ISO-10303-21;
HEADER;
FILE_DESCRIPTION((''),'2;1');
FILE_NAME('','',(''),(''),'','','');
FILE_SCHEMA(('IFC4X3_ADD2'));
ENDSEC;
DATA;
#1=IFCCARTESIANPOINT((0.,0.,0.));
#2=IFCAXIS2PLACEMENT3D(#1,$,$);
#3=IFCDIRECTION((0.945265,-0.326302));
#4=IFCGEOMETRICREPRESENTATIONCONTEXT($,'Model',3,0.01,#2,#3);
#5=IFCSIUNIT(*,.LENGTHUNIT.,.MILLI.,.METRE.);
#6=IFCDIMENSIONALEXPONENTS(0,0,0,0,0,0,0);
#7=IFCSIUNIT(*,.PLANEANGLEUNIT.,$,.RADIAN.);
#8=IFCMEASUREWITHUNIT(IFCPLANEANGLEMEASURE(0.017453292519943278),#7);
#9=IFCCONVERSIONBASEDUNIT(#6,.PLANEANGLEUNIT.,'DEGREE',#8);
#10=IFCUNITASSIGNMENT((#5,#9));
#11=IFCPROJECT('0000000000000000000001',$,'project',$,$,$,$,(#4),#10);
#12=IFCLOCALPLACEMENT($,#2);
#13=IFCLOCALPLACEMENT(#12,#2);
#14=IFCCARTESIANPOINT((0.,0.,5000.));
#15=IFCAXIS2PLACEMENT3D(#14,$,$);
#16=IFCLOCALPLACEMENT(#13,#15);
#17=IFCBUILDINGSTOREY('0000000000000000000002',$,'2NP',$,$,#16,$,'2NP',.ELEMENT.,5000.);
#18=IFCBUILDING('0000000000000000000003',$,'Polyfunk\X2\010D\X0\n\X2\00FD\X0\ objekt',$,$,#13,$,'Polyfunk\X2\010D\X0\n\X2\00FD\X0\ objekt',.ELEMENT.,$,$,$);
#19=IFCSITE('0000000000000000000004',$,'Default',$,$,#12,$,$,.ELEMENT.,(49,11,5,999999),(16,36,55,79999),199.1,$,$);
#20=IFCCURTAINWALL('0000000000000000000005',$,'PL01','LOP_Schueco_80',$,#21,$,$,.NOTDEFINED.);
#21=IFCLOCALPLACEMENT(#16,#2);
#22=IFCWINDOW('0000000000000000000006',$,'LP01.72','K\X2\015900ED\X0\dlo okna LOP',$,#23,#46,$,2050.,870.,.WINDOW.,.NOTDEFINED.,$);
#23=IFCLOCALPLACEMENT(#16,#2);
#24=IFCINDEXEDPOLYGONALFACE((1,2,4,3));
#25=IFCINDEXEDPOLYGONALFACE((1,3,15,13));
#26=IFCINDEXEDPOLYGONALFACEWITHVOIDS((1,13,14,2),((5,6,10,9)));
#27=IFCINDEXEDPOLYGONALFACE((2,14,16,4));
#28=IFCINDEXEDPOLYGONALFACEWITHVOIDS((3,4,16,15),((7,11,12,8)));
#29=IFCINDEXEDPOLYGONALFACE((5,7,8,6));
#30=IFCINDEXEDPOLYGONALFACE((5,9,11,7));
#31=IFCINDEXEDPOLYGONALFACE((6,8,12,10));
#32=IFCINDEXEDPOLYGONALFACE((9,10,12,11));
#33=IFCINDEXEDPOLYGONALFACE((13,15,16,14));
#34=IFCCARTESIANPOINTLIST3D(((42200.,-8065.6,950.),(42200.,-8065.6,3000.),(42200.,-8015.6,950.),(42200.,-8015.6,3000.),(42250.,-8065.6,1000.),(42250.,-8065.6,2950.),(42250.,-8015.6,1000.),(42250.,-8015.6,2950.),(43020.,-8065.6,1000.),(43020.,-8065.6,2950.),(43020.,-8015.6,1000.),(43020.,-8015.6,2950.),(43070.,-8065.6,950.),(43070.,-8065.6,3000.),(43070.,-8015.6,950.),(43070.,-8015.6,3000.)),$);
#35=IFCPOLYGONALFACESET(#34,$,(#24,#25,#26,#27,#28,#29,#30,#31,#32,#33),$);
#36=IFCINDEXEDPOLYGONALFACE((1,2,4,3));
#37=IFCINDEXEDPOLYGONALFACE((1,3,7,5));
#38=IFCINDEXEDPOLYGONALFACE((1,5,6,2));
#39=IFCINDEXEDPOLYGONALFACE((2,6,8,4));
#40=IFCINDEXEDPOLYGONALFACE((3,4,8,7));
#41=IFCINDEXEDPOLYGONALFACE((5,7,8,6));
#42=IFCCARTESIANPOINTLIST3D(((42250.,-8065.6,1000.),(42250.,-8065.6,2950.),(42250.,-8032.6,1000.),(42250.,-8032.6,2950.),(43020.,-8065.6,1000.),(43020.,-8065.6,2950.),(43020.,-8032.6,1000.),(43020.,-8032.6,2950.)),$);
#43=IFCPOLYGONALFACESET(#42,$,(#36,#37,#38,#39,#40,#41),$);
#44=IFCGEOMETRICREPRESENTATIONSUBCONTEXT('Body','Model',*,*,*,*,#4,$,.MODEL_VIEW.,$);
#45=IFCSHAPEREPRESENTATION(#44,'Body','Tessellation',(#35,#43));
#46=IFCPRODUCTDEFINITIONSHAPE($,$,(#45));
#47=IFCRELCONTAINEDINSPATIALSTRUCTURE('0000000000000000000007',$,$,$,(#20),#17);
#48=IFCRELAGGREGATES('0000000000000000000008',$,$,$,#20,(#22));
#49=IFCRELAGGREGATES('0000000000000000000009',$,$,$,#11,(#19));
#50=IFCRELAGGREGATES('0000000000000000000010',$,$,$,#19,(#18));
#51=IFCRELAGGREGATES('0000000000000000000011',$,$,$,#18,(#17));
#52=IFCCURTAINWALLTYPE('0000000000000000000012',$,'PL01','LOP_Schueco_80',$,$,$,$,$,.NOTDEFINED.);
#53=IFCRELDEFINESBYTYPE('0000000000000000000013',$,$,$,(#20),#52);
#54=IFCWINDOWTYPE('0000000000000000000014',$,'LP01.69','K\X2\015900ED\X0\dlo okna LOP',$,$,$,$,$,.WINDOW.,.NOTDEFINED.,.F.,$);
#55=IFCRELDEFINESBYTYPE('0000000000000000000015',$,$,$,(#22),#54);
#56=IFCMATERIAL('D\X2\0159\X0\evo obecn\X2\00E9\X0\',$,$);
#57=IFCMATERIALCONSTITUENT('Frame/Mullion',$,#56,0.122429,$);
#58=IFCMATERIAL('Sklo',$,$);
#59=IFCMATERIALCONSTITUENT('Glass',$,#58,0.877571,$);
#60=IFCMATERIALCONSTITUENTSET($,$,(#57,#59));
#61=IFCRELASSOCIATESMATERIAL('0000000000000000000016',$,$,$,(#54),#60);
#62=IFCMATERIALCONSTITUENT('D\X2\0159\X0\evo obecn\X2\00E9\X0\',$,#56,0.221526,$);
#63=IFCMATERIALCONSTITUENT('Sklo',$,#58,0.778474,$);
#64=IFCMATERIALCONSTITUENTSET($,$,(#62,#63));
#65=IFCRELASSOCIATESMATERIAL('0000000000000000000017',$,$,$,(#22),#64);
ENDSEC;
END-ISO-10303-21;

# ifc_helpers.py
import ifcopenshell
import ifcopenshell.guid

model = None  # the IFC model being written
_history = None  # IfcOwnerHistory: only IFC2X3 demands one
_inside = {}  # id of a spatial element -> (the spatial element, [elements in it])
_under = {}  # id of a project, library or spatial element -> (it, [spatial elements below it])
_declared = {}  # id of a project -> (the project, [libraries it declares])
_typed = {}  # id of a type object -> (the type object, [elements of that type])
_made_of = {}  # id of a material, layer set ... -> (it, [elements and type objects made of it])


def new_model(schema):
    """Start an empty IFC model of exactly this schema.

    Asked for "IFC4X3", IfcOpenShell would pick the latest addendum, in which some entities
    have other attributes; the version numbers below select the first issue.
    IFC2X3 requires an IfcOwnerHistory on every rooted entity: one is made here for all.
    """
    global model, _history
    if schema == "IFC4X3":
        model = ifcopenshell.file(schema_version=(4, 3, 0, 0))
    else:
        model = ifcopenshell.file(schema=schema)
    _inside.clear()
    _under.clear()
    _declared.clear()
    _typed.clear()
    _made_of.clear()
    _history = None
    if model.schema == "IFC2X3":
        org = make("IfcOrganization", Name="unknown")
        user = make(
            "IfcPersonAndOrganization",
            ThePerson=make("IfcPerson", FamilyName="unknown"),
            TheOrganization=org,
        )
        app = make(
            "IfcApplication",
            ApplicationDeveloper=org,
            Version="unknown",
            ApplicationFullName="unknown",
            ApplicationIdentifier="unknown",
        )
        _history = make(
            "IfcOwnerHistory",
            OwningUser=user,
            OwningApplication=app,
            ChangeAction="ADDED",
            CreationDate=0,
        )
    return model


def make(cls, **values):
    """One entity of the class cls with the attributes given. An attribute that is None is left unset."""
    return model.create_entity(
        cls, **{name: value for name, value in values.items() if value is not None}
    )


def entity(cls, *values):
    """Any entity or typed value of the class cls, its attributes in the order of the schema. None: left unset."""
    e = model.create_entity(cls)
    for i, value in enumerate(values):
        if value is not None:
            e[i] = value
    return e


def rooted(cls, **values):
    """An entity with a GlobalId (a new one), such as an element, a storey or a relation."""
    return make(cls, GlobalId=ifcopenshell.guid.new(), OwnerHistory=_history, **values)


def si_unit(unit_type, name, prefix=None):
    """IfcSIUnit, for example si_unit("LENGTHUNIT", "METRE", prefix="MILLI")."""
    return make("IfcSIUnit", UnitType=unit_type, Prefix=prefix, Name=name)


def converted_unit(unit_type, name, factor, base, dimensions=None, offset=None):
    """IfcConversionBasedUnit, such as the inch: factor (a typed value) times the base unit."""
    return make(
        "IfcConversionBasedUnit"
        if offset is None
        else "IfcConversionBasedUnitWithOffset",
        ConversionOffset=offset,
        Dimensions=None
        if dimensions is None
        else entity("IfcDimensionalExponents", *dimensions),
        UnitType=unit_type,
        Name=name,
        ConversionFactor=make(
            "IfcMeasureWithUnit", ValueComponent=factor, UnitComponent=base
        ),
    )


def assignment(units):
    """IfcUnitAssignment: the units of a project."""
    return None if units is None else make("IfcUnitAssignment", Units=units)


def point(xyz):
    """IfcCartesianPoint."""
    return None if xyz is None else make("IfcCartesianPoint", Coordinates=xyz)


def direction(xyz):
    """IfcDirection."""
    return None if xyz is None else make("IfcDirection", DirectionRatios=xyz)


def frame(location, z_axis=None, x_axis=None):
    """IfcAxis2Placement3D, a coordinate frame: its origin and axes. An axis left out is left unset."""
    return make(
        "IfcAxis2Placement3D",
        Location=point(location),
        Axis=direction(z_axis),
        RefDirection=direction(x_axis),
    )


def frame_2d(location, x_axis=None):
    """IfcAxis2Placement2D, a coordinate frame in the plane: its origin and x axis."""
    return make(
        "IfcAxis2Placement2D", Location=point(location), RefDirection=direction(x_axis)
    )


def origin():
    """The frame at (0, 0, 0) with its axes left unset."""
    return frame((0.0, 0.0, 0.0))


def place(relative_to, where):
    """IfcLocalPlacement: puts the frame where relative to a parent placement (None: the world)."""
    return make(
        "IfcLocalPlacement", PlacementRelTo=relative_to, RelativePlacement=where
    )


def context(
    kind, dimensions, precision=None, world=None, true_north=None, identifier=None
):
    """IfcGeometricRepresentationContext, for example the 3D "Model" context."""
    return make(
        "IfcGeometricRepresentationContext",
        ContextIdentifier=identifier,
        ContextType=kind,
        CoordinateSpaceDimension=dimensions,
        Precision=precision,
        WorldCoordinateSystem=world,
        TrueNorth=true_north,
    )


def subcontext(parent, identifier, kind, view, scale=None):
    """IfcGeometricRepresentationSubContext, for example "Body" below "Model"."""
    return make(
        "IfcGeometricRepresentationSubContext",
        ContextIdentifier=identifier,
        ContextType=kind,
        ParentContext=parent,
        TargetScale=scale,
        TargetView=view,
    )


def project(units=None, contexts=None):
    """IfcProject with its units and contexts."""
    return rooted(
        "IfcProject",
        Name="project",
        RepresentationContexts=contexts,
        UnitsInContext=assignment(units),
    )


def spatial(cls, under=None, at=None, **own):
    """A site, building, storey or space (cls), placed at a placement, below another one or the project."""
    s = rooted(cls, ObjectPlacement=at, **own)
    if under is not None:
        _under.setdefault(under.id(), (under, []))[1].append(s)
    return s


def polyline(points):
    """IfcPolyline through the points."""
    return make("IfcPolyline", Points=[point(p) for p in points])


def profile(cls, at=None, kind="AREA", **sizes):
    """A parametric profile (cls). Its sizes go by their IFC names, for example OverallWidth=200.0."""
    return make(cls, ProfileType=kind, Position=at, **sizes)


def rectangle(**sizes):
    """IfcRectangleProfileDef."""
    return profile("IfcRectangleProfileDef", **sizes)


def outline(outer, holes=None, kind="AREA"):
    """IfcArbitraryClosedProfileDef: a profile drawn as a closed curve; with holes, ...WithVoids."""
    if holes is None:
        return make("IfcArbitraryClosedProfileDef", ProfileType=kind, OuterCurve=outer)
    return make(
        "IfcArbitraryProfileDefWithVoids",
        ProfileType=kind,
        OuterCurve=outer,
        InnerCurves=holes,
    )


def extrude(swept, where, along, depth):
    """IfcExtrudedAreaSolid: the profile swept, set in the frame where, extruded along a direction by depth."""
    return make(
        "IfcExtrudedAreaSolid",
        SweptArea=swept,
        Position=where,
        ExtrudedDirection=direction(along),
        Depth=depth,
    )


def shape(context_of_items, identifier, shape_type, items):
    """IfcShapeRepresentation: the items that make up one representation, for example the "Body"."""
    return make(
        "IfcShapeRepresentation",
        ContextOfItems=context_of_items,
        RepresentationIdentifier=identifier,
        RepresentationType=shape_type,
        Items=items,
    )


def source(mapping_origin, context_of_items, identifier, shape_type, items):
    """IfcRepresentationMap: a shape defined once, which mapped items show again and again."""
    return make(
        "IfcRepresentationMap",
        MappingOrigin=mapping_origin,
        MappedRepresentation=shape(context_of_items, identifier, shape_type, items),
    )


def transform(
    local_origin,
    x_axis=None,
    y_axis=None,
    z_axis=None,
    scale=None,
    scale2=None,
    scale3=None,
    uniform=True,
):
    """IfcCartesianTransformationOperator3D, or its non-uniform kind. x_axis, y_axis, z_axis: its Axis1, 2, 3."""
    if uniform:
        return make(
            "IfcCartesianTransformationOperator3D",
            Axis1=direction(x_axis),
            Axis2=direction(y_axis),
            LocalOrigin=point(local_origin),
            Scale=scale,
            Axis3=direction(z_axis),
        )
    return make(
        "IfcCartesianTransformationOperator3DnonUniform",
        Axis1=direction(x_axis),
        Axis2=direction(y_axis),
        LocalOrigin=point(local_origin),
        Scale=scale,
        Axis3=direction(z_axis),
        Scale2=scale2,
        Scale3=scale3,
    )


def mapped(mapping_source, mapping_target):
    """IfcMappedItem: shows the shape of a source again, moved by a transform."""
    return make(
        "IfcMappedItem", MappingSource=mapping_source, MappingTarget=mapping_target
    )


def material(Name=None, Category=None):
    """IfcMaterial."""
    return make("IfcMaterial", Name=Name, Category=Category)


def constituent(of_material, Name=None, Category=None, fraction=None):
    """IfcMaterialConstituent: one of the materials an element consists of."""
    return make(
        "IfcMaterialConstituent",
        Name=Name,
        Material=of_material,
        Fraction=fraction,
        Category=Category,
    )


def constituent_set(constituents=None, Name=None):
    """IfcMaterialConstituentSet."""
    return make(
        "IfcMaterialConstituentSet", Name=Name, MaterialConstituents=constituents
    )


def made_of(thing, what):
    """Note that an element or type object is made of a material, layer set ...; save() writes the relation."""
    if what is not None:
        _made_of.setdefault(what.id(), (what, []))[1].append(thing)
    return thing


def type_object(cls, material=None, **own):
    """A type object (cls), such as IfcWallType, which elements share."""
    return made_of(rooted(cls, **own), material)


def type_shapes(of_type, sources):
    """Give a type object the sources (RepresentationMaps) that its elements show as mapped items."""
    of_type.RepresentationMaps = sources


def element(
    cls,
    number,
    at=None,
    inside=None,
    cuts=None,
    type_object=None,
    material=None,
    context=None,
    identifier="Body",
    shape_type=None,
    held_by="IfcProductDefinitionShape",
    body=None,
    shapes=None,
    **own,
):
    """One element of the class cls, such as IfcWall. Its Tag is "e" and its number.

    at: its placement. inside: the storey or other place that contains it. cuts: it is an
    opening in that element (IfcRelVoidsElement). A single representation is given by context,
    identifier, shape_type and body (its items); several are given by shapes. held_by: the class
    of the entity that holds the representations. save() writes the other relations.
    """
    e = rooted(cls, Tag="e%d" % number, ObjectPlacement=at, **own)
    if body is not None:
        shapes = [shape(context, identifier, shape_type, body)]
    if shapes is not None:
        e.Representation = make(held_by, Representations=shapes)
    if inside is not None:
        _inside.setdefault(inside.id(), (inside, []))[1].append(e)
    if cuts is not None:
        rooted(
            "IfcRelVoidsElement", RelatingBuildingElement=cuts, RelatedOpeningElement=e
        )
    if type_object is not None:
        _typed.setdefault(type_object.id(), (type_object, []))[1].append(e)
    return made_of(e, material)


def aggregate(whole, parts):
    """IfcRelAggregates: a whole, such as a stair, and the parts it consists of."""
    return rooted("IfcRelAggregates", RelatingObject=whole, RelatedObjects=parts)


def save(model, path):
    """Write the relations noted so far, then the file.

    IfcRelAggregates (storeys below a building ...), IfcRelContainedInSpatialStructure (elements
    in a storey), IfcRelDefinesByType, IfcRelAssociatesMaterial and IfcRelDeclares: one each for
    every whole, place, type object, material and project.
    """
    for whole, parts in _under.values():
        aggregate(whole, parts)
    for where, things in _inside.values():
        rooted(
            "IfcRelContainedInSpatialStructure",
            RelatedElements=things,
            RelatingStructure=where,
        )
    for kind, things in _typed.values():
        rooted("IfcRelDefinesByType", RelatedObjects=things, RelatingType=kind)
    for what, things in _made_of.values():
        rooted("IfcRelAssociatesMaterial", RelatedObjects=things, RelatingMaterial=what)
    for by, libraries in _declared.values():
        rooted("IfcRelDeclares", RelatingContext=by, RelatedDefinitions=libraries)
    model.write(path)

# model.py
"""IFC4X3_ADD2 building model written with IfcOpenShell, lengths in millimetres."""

from ifc_helpers import new_model, entity, si_unit, converted_unit, direction, frame, frame_2d, origin, place, context, subcontext, project, spatial, polyline, rectangle, outline, extrude, source, transform, mapped, material, constituent, constituent_set, type_object, type_shapes, element, aggregate, save


model = new_model("IFC4X3_ADD2")

# Units and contexts
model_context = context("Model", 3, precision=0.01, world=origin(), true_north=direction((0.945265, -0.326302)))
body_context = subcontext(model_context, "Body", "Model", "MODEL_VIEW")
ifc_project = project(units=[si_unit("LENGTHUNIT", "METRE", prefix="MILLI"), converted_unit("PLANEANGLEUNIT", "DEGREE", entity("IfcPlaneAngleMeasure", 0.017453292519943278), si_unit("PLANEANGLEUNIT", "RADIAN"), dimensions=[0, 0, 0, 0, 0, 0, 0])], contexts=[model_context])

# Site, building, storey
site_placement = place(None, origin())
site = spatial("IfcSite", under=ifc_project, at=site_placement, Name="Default", CompositionType="ELEMENT", RefLatitude=(49, 11, 5, 999999), RefLongitude=(16, 36, 55, 79999), RefElevation=199.1)
building_placement = place(site_placement, origin())
building = spatial("IfcBuilding", under=site, at=building_placement, Name="Polyfunkčný objekt", LongName="Polyfunkčný objekt", CompositionType="ELEMENT")
storey_placement = place(building_placement, frame((0.0, 0.0, 5000.0)))
storey = spatial("IfcBuildingStorey", under=building, at=storey_placement, Name="2NP", LongName="2NP", CompositionType="ELEMENT", Elevation=5000.0)

# Curtain wall
curtain_wall_type = type_object("IfcCurtainWallType", Name="PL01", Description="LOP_Schueco_80", PredefinedType="NOTDEFINED")
curtain_wall_placement = place(storey_placement, frame((0.0, 0.0, -5000.0)))
curtain_wall = element("IfcCurtainWall", 1, at=curtain_wall_placement, inside=storey, type_object=curtain_wall_type, Name="PL01", Description="LOP_Schueco_80", PredefinedType="NOTDEFINED")
ifc_material_1 = material(Name="Sklo")

# Window
ifc_material_2 = material(Name="Dřevo obecné")
ifc_constituent_1 = constituent(ifc_material_2, Name="Dřevo obecné", fraction=0.221526)
ifc_constituent_2 = constituent(ifc_material_1, Name="Sklo", fraction=0.778474)
ifc_constituent_set_1 = constituent_set(constituents=[ifc_constituent_1, ifc_constituent_2])
ifc_constituent_3 = constituent(ifc_material_2, Name="Frame/Mullion", fraction=0.122429)
ifc_constituent_4 = constituent(ifc_material_1, Name="Glass", fraction=0.877571)
ifc_constituent_set_2 = constituent_set(constituents=[ifc_constituent_3, ifc_constituent_4])
window_type = type_object("IfcWindowType", Name="LP01.69", Description="Křídlo okna LOP", ParameterTakesPrecedence=False, PartitioningType="NOTDEFINED", PredefinedType="WINDOW", material=ifc_constituent_set_2)
shared_shape_1 = source(origin(), body_context, "Body", "SweptSolid", [
    extrude(outline(polyline([(-1025.0, -435.0), (1025.0, -435.0), (1025.0, 435.0), (-1025.0, 435.0), (-1025.0, -435.0)]), holes=[polyline([(-975.0, -385.0), (-975.0, 385.0), (975.0, 385.0), (975.0, -385.0), (-975.0, -385.0)])]), frame((0.0, 50.0, 1025.0), z_axis=(0.0, -1.0, 0.0), x_axis=(0.0, 0.0, -1.0)), (0.0, 0.0, 1.0), 50.0),
    extrude(rectangle(XDim=770.0, YDim=33.0, at=frame_2d((0.0, 0.0), x_axis=(1.0, 0.0))), frame((0.0, 33.5, 50.0), z_axis=(0.0, 0.0, 1.0), x_axis=(-1.0, 0.0, 0.0)), (0.0, 0.0, 1.0), 1950.0),
])
type_shapes(window_type, [shared_shape_1])
window_placement = place(curtain_wall_placement, frame((42635.0, -8015.6, 5950.0), z_axis=(0.0, 0.0, 1.0), x_axis=(-1.0, 0.0, 0.0)))
window = element("IfcWindow", 2, at=window_placement, type_object=window_type, material=ifc_constituent_set_1, Name="LP01.72", Description="Křídlo okna LOP", OverallHeight=2050.0, OverallWidth=870.0, PartitioningType="NOTDEFINED", PredefinedType="WINDOW", context=body_context, shape_type="MappedRepresentation", body=[
    mapped(shared_shape_1, transform((0.0, 0.0, 0.0), scale=1.0)),
])
aggregate(curtain_wall, [window])

save(model, "model.ifc")
